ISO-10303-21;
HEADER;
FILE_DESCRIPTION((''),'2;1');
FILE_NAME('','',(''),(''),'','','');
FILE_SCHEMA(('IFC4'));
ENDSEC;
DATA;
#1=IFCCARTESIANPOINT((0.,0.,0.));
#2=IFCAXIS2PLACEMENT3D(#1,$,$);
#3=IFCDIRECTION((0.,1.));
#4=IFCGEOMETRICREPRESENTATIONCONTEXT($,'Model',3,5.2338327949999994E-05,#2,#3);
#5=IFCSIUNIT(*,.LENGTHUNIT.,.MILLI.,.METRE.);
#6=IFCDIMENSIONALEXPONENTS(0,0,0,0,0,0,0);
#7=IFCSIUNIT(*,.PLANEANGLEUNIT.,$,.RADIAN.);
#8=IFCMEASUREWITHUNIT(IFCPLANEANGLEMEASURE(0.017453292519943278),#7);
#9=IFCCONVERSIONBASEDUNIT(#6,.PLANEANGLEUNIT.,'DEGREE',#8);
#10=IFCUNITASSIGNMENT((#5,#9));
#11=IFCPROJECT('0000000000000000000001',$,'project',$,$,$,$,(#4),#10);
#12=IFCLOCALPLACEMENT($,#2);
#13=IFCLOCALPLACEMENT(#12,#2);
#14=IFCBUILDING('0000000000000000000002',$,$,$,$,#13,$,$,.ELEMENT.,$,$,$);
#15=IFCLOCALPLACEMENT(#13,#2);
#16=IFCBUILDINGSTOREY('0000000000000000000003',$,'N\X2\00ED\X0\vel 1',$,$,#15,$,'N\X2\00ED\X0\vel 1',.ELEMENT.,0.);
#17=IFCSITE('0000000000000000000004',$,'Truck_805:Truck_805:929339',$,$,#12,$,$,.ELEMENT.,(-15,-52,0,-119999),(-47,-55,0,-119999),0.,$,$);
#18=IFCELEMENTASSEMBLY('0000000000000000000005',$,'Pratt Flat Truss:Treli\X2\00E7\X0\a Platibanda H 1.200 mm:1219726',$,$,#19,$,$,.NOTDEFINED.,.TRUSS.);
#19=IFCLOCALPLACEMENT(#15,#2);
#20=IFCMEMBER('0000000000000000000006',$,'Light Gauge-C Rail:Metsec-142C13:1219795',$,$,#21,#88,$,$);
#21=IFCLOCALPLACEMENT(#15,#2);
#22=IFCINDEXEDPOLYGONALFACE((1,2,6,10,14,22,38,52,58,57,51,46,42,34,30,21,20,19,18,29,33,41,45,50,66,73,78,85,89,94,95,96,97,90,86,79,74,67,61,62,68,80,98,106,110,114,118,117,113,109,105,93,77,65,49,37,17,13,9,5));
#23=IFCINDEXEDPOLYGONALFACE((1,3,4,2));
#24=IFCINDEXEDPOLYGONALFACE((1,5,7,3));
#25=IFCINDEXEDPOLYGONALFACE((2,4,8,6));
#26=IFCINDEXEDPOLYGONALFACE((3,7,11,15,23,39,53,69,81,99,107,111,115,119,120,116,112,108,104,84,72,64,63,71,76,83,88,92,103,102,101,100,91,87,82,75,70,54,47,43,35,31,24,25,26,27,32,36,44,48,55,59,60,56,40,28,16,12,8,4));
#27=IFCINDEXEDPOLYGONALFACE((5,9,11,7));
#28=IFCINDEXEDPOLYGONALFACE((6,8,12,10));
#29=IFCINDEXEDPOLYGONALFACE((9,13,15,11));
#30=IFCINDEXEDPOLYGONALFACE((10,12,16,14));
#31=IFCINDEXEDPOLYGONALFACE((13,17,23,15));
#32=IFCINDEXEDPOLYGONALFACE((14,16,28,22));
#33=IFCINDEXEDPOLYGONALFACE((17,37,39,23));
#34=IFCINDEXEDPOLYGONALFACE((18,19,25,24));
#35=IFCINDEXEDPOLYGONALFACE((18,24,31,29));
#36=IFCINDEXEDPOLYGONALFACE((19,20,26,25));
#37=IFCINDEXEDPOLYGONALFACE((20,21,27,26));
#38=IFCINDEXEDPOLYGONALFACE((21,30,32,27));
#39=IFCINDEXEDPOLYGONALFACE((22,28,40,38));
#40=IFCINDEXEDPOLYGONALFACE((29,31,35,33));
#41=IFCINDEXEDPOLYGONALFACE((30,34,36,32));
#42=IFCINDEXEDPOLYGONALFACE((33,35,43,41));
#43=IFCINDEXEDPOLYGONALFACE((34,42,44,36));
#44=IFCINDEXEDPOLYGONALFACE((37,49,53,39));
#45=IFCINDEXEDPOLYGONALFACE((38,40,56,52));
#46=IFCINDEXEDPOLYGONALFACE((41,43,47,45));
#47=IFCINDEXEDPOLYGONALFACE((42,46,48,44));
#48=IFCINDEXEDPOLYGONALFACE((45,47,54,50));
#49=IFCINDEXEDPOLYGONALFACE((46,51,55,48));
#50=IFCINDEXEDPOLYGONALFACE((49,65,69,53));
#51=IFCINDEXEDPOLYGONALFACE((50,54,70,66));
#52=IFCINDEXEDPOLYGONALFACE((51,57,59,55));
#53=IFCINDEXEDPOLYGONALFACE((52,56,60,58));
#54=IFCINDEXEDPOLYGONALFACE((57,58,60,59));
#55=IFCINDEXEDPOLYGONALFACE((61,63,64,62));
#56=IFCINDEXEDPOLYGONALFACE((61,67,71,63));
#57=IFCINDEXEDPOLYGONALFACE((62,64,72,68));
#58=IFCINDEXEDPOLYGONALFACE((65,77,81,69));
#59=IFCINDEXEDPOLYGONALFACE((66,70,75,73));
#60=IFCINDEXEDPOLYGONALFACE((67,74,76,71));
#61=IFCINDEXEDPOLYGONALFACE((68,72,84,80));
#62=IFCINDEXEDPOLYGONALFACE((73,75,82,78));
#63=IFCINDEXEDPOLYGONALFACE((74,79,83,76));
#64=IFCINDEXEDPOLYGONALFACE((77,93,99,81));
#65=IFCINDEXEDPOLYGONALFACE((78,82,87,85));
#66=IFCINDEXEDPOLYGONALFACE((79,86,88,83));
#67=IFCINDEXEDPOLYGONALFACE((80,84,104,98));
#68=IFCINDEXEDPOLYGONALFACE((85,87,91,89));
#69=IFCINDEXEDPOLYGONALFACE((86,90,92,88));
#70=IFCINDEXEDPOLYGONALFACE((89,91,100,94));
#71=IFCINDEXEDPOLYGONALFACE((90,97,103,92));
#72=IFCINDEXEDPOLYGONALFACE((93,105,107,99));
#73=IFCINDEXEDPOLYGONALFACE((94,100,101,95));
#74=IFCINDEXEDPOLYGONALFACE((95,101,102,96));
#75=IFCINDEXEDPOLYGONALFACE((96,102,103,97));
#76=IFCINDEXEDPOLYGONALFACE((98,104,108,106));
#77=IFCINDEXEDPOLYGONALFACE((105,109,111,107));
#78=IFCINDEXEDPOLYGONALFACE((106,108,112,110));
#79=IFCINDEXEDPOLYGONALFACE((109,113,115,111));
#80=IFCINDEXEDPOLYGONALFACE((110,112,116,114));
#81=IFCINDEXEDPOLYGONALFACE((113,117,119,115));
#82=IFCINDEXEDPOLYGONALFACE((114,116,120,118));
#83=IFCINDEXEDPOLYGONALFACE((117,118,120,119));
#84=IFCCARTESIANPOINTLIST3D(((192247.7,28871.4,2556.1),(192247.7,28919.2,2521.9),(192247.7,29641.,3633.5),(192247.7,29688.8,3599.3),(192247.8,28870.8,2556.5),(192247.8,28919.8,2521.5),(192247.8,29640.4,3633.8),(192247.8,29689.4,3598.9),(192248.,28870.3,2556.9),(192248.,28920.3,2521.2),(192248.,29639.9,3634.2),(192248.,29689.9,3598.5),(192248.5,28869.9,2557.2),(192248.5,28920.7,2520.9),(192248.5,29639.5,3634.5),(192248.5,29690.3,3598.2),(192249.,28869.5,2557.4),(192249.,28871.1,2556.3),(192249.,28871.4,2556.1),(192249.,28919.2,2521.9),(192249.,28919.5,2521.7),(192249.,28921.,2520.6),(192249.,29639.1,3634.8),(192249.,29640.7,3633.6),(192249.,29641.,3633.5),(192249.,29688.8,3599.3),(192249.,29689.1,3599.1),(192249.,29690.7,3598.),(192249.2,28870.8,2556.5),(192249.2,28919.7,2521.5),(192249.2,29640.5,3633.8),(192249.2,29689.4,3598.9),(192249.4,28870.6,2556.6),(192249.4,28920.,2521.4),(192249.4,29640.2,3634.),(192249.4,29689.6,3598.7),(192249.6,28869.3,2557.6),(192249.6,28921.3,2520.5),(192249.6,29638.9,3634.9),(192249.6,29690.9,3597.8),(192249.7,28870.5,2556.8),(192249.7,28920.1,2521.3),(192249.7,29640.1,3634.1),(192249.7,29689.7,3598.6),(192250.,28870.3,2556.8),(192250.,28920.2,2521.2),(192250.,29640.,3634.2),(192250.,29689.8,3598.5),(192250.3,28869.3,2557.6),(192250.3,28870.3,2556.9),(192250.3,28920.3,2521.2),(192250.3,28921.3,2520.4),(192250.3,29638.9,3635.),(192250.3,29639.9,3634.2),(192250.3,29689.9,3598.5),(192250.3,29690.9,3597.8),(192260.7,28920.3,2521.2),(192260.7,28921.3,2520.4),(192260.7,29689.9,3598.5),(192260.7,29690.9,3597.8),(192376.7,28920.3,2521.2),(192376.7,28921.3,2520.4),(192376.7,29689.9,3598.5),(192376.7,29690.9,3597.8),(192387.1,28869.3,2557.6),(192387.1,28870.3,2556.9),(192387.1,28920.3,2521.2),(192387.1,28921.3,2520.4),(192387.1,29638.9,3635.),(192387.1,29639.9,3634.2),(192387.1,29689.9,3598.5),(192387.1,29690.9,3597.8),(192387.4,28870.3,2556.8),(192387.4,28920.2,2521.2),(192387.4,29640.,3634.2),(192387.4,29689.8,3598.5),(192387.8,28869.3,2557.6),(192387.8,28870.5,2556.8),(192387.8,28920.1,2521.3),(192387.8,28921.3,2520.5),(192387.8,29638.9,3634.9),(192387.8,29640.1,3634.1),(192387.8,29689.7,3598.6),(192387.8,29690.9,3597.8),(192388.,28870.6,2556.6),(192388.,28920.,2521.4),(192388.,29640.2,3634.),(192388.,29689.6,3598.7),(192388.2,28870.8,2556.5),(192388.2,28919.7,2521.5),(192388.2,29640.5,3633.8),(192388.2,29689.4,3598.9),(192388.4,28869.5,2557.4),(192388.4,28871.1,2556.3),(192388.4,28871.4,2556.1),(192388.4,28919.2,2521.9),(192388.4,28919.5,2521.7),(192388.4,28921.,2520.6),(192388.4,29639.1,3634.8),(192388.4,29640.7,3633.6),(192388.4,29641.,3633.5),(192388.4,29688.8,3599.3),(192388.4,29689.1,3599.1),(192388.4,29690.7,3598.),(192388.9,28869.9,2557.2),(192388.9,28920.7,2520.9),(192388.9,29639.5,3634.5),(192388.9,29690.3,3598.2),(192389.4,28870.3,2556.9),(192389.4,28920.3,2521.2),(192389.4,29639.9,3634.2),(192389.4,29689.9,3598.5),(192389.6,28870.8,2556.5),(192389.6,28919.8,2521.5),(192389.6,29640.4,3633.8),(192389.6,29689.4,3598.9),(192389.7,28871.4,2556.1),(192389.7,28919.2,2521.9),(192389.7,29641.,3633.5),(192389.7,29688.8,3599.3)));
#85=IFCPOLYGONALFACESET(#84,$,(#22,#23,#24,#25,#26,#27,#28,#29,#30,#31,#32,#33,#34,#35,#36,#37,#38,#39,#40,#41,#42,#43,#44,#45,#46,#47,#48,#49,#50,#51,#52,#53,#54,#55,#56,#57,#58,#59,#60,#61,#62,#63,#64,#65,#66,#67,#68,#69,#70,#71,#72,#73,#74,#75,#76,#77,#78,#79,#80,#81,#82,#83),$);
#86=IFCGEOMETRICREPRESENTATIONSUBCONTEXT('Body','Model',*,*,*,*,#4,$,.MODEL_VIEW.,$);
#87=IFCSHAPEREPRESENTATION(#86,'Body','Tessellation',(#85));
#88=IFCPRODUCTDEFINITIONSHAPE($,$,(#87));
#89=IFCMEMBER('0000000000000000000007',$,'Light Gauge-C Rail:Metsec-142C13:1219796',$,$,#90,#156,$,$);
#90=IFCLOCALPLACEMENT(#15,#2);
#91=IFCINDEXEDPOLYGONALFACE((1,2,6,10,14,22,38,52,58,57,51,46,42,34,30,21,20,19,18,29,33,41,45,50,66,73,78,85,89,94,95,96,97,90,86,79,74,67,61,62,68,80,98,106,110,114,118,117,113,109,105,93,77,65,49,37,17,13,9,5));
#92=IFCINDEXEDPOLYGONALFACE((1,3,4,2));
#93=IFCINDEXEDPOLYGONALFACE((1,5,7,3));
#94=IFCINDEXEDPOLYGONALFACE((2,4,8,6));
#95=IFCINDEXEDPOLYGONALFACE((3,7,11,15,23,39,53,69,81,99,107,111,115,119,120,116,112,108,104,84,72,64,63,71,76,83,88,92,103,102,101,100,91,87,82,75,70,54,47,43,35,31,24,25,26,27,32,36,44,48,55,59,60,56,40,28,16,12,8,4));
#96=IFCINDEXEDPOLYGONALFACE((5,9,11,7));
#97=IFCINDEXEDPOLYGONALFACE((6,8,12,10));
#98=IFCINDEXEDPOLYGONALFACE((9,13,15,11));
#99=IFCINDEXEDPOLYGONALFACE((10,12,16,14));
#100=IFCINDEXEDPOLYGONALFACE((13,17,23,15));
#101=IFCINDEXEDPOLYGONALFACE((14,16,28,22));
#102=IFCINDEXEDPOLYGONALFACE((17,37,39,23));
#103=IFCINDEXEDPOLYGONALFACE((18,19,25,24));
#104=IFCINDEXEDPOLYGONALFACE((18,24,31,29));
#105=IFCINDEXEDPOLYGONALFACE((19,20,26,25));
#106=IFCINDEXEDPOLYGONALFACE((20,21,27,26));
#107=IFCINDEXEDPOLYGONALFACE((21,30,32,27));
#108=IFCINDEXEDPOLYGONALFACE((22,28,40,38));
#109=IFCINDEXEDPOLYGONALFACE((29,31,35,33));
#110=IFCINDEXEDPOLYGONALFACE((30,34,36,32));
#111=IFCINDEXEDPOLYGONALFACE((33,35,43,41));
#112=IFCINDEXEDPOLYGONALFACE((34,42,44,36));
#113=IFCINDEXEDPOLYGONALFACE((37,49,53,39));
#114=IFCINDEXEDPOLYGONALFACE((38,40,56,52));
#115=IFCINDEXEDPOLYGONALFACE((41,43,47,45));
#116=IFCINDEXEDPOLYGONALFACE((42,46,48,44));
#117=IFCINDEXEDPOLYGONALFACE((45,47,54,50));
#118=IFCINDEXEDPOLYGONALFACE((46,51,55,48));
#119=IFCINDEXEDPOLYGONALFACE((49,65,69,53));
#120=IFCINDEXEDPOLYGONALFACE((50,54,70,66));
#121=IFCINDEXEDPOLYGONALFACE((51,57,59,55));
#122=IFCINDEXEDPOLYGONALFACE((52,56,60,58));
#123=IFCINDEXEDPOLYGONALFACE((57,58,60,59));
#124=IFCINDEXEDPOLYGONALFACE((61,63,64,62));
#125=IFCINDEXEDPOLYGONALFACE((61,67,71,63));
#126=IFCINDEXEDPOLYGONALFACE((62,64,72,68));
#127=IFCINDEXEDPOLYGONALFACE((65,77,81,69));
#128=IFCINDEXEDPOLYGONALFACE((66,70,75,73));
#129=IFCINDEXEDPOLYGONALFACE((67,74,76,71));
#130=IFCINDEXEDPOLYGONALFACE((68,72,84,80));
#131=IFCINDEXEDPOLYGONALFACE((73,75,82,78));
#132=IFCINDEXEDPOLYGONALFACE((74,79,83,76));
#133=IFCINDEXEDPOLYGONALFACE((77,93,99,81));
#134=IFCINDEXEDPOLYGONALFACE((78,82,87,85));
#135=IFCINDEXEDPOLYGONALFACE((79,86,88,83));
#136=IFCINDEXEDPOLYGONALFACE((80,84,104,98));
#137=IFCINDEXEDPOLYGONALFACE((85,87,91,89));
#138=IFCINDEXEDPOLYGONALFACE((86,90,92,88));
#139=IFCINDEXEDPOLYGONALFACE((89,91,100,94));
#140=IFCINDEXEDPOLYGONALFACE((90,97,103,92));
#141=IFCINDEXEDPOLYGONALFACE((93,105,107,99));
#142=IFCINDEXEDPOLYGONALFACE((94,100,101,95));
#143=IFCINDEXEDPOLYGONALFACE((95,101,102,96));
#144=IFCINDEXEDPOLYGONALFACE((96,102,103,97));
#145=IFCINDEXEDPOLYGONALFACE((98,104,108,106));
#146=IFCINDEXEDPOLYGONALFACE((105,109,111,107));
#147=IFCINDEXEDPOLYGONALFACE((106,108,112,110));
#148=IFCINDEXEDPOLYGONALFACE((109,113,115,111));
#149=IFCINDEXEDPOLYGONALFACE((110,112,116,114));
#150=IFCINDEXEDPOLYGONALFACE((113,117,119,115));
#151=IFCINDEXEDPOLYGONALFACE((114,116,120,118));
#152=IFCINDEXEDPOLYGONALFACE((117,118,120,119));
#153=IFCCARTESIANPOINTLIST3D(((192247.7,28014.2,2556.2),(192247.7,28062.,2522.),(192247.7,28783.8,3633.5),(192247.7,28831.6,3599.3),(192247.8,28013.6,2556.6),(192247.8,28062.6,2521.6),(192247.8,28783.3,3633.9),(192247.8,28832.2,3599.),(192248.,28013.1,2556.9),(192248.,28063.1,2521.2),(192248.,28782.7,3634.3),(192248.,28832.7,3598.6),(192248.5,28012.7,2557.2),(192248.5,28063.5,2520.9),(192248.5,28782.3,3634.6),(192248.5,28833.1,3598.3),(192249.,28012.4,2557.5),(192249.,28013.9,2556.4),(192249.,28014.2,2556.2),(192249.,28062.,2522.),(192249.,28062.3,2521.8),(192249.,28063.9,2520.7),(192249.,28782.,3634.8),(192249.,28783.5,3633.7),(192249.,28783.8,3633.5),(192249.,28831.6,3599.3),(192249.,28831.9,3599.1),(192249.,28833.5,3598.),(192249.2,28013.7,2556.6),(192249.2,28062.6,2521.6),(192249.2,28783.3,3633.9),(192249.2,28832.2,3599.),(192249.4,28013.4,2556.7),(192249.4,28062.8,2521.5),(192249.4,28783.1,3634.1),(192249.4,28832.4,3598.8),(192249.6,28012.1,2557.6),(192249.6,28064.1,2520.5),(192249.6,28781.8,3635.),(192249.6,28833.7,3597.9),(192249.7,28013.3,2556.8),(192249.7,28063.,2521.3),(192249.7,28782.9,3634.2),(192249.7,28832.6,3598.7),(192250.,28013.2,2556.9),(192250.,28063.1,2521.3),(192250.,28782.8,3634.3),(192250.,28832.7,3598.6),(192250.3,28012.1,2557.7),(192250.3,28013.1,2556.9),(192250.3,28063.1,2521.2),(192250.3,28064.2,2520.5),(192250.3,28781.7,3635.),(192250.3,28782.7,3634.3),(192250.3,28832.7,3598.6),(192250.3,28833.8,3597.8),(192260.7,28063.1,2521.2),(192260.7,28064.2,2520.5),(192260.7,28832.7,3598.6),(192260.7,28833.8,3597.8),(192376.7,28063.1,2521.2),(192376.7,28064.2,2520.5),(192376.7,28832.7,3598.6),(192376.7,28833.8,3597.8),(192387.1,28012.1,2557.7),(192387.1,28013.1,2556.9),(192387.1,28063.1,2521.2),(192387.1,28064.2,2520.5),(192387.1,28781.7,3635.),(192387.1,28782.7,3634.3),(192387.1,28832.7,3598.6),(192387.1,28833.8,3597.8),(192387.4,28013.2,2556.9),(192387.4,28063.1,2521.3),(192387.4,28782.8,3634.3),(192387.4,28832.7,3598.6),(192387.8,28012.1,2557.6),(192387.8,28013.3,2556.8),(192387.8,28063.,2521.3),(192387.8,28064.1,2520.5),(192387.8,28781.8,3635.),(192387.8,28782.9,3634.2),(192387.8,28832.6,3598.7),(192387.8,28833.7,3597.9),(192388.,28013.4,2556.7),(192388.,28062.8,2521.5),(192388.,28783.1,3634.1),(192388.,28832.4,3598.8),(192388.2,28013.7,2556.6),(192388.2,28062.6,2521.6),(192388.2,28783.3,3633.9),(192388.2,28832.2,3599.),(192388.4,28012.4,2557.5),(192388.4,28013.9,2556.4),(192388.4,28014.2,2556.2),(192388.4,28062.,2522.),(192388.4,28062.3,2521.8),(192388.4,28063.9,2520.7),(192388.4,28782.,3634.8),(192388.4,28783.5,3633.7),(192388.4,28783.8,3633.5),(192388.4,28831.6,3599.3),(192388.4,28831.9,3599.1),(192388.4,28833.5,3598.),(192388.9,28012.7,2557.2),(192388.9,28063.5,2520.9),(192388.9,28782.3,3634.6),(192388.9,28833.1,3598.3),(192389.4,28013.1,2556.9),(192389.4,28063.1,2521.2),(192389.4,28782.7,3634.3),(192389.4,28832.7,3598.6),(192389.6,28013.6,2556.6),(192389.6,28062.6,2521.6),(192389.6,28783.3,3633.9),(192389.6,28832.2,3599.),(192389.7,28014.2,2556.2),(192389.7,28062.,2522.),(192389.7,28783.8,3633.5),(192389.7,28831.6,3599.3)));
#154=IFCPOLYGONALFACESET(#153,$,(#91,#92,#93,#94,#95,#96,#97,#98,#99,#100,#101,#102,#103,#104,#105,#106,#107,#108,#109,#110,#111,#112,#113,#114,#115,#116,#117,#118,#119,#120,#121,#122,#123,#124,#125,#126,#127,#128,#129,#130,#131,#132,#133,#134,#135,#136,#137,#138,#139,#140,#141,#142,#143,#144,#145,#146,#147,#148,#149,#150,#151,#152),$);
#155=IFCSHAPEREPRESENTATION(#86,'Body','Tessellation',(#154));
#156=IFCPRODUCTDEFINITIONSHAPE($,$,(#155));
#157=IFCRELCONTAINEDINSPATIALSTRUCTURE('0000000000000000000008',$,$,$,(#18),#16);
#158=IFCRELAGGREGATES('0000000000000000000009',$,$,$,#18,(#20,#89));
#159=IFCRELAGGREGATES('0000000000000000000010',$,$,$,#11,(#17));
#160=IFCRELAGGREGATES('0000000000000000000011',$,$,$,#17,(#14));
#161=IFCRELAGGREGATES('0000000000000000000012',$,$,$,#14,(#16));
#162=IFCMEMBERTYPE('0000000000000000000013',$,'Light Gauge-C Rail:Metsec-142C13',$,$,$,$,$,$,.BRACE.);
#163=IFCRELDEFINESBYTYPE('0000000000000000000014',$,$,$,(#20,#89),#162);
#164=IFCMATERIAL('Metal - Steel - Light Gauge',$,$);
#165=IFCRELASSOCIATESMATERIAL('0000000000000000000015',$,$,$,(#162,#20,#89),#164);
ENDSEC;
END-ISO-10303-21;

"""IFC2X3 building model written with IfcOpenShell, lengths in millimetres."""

from ifc_helpers import new_model, entity, si_unit, converted_unit, direction, frame, frame_2d, origin, place, context, subcontext, project, spatial, polyline, circle_curve, parameter, trimmed, segment, composite_curve, outline, extrude, source, transform, mapped, material, type_object, type_shapes, element, aggregate, save


model = new_model("IFC2X3")

# Units and contexts
model_context = context("Model", 3, precision=5.2338327949999994e-05, world=origin(), true_north=direction((0.0, 1.0)))
body_context = subcontext(model_context, "Body", "Model", "MODEL_VIEW")
ifc_project = project(units=[si_unit("LENGTHUNIT", "METRE", prefix="MILLI"), converted_unit("PLANEANGLEUNIT", "DEGREE", entity("IfcPlaneAngleMeasure", 0.017453292519943278), si_unit("PLANEANGLEUNIT", "RADIAN"), dimensions=[0, 0, 0, 0, 0, 0, 0])], contexts=[model_context])

# Site, building, storey
site_placement = place(None, origin())
site = spatial("IfcSite", under=ifc_project, at=site_placement, Name="Truck_805:Truck_805:929339", CompositionType="ELEMENT", RefLatitude=(-15, -52, 0, -119999), RefLongitude=(-47, -55, 0, -119999), RefElevation=0.0)
building_placement = place(site_placement, origin())
building = spatial("IfcBuilding", under=site, at=building_placement, CompositionType="ELEMENT")
storey_placement = place(building_placement, origin())
storey = spatial("IfcBuildingStorey", under=building, at=storey_placement, Name="Nível 1", LongName="Nível 1", CompositionType="ELEMENT", Elevation=0.0)

# Element assembly, members
assembly_1_placement = place(storey_placement, origin())
assembly_1 = element("IfcElementAssembly", 1, at=assembly_1_placement, inside=storey, Name="Pratt Flat Truss:Treliça Platibanda H 1.200 mm:1219726", AssemblyPlace="NOTDEFINED", PredefinedType="TRUSS")
ifc_material_1 = material(Name="Metal - Steel - Light Gauge")
member_type_1 = type_object("IfcMemberType", Name="Light Gauge-C Rail:Metsec-142C13", PredefinedType="BRACE", material=ifc_material_1)
shared_shape_1 = source(origin(), body_context, "Body", "SweptSolid", [
    extrude(outline(composite_curve([segment(polyline([(-23.1, -71.0), (35.7, -71.0)]), True, "CONTINUOUS"), segment(trimmed(circle_curve(frame_2d((35.7, -68.4), x_axis=(0.0, -1.0)), 2.6), [parameter(0.0)], [parameter(90.0)], True, "PARAMETER"), True, "CONTINUOUS"), segment(polyline([(38.3, -68.4), (38.3, 68.4)]), True, "CONTINUOUS"), segment(trimmed(circle_curve(frame_2d((35.7, 68.4), x_axis=(1.0, 0.0)), 2.6), [parameter(0.0)], [parameter(90.0)], True, "PARAMETER"), True, "CONTINUOUS"), segment(polyline([(35.7, 71.0), (-23.1, 71.0)]), True, "CONTINUOUS"), segment(trimmed(circle_curve(frame_2d((-23.1, 68.4), x_axis=(0.0, 1.0)), 2.6), [parameter(0.0)], [parameter(90.0)], True, "PARAMETER"), True, "CONTINUOUS"), segment(polyline([(-25.7, 68.4), (-25.7, 58.0)]), True, "CONTINUOUS"), segment(polyline([(-25.7, 58.0), (-24.4, 58.0)]), True, "CONTINUOUS"), segment(polyline([(-24.4, 58.0), (-24.4, 68.4)]), True, "CONTINUOUS"), segment(trimmed(circle_curve(frame_2d((-23.1, 68.4), x_axis=(-1.0, 0.0)), 1.3), [parameter(270.0)], [parameter(0.0)], True, "PARAMETER"), False, "CONTINUOUS"), segment(polyline([(-23.1, 69.7), (35.7, 69.7)]), True, "CONTINUOUS"), segment(trimmed(circle_curve(frame_2d((35.7, 68.4), x_axis=(0.0, 1.0)), 1.3), [parameter(270.0)], [parameter(0.0)], True, "PARAMETER"), False, "CONTINUOUS"), segment(polyline([(37.0, 68.4), (37.0, -68.4)]), True, "CONTINUOUS"), segment(trimmed(circle_curve(frame_2d((35.7, -68.4), x_axis=(1.0, 0.0)), 1.3), [parameter(270.0)], [parameter(0.0)], True, "PARAMETER"), False, "CONTINUOUS"), segment(polyline([(35.7, -69.7), (-23.1, -69.7)]), True, "CONTINUOUS"), segment(trimmed(circle_curve(frame_2d((-23.1, -68.4), x_axis=(0.0, -1.0)), 1.3), [parameter(270.0)], [parameter(0.0)], True, "PARAMETER"), False, "CONTINUOUS"), segment(polyline([(-24.4, -68.4), (-24.4, -58.0)]), True, "CONTINUOUS"), segment(polyline([(-24.4, -58.0), (-25.7, -58.0)]), True, "CONTINUOUS"), segment(polyline([(-25.7, -58.0), (-25.7, -68.4)]), True, "CONTINUOUS"), segment(trimmed(circle_curve(frame_2d((-23.1, -68.4), x_axis=(-1.0, 0.0)), 2.6), [parameter(0.0)], [parameter(90.0)], True, "PARAMETER"), True, "CONTINUOUS")], self_intersect=False)), frame((-671.0, 0.0, 18.8), z_axis=(1.0, 0.0, 0.0), x_axis=(0.0, 0.0, -1.0)), (0.0, 0.0, 1.0), 1324.0),
])
type_shapes(member_type_1, [shared_shape_1])
member_1_placement = place(assembly_1_placement, frame((192318.7, 29264.7, 3077.6), z_axis=(0.0, 0.813705, -0.581278), x_axis=(0.0, -0.581278, -0.813705)))
member_1 = element("IfcMember", 2, at=member_1_placement, type_object=member_type_1, material=ifc_material_1, Name="Light Gauge-C Rail:Metsec-142C13:1219795", context=body_context, shape_type="MappedRepresentation", body=[
    mapped(shared_shape_1, transform((0.0, 0.0, 0.0), scale=1.0)),
])
member_2_placement = place(assembly_1_placement, frame((192318.7, 28407.5, 3077.7), z_axis=(0.0, 0.813705, -0.581278), x_axis=(0.0, -0.581278, -0.813705)))
member_2 = element("IfcMember", 3, at=member_2_placement, type_object=member_type_1, material=ifc_material_1, Name="Light Gauge-C Rail:Metsec-142C13:1219796", context=body_context, shape_type="MappedRepresentation", body=[
    mapped(shared_shape_1, transform((0.0, 0.0, 0.0), scale=1.0)),
])
aggregate(assembly_1, [member_1, member_2])

save(model, "model.ifc")
